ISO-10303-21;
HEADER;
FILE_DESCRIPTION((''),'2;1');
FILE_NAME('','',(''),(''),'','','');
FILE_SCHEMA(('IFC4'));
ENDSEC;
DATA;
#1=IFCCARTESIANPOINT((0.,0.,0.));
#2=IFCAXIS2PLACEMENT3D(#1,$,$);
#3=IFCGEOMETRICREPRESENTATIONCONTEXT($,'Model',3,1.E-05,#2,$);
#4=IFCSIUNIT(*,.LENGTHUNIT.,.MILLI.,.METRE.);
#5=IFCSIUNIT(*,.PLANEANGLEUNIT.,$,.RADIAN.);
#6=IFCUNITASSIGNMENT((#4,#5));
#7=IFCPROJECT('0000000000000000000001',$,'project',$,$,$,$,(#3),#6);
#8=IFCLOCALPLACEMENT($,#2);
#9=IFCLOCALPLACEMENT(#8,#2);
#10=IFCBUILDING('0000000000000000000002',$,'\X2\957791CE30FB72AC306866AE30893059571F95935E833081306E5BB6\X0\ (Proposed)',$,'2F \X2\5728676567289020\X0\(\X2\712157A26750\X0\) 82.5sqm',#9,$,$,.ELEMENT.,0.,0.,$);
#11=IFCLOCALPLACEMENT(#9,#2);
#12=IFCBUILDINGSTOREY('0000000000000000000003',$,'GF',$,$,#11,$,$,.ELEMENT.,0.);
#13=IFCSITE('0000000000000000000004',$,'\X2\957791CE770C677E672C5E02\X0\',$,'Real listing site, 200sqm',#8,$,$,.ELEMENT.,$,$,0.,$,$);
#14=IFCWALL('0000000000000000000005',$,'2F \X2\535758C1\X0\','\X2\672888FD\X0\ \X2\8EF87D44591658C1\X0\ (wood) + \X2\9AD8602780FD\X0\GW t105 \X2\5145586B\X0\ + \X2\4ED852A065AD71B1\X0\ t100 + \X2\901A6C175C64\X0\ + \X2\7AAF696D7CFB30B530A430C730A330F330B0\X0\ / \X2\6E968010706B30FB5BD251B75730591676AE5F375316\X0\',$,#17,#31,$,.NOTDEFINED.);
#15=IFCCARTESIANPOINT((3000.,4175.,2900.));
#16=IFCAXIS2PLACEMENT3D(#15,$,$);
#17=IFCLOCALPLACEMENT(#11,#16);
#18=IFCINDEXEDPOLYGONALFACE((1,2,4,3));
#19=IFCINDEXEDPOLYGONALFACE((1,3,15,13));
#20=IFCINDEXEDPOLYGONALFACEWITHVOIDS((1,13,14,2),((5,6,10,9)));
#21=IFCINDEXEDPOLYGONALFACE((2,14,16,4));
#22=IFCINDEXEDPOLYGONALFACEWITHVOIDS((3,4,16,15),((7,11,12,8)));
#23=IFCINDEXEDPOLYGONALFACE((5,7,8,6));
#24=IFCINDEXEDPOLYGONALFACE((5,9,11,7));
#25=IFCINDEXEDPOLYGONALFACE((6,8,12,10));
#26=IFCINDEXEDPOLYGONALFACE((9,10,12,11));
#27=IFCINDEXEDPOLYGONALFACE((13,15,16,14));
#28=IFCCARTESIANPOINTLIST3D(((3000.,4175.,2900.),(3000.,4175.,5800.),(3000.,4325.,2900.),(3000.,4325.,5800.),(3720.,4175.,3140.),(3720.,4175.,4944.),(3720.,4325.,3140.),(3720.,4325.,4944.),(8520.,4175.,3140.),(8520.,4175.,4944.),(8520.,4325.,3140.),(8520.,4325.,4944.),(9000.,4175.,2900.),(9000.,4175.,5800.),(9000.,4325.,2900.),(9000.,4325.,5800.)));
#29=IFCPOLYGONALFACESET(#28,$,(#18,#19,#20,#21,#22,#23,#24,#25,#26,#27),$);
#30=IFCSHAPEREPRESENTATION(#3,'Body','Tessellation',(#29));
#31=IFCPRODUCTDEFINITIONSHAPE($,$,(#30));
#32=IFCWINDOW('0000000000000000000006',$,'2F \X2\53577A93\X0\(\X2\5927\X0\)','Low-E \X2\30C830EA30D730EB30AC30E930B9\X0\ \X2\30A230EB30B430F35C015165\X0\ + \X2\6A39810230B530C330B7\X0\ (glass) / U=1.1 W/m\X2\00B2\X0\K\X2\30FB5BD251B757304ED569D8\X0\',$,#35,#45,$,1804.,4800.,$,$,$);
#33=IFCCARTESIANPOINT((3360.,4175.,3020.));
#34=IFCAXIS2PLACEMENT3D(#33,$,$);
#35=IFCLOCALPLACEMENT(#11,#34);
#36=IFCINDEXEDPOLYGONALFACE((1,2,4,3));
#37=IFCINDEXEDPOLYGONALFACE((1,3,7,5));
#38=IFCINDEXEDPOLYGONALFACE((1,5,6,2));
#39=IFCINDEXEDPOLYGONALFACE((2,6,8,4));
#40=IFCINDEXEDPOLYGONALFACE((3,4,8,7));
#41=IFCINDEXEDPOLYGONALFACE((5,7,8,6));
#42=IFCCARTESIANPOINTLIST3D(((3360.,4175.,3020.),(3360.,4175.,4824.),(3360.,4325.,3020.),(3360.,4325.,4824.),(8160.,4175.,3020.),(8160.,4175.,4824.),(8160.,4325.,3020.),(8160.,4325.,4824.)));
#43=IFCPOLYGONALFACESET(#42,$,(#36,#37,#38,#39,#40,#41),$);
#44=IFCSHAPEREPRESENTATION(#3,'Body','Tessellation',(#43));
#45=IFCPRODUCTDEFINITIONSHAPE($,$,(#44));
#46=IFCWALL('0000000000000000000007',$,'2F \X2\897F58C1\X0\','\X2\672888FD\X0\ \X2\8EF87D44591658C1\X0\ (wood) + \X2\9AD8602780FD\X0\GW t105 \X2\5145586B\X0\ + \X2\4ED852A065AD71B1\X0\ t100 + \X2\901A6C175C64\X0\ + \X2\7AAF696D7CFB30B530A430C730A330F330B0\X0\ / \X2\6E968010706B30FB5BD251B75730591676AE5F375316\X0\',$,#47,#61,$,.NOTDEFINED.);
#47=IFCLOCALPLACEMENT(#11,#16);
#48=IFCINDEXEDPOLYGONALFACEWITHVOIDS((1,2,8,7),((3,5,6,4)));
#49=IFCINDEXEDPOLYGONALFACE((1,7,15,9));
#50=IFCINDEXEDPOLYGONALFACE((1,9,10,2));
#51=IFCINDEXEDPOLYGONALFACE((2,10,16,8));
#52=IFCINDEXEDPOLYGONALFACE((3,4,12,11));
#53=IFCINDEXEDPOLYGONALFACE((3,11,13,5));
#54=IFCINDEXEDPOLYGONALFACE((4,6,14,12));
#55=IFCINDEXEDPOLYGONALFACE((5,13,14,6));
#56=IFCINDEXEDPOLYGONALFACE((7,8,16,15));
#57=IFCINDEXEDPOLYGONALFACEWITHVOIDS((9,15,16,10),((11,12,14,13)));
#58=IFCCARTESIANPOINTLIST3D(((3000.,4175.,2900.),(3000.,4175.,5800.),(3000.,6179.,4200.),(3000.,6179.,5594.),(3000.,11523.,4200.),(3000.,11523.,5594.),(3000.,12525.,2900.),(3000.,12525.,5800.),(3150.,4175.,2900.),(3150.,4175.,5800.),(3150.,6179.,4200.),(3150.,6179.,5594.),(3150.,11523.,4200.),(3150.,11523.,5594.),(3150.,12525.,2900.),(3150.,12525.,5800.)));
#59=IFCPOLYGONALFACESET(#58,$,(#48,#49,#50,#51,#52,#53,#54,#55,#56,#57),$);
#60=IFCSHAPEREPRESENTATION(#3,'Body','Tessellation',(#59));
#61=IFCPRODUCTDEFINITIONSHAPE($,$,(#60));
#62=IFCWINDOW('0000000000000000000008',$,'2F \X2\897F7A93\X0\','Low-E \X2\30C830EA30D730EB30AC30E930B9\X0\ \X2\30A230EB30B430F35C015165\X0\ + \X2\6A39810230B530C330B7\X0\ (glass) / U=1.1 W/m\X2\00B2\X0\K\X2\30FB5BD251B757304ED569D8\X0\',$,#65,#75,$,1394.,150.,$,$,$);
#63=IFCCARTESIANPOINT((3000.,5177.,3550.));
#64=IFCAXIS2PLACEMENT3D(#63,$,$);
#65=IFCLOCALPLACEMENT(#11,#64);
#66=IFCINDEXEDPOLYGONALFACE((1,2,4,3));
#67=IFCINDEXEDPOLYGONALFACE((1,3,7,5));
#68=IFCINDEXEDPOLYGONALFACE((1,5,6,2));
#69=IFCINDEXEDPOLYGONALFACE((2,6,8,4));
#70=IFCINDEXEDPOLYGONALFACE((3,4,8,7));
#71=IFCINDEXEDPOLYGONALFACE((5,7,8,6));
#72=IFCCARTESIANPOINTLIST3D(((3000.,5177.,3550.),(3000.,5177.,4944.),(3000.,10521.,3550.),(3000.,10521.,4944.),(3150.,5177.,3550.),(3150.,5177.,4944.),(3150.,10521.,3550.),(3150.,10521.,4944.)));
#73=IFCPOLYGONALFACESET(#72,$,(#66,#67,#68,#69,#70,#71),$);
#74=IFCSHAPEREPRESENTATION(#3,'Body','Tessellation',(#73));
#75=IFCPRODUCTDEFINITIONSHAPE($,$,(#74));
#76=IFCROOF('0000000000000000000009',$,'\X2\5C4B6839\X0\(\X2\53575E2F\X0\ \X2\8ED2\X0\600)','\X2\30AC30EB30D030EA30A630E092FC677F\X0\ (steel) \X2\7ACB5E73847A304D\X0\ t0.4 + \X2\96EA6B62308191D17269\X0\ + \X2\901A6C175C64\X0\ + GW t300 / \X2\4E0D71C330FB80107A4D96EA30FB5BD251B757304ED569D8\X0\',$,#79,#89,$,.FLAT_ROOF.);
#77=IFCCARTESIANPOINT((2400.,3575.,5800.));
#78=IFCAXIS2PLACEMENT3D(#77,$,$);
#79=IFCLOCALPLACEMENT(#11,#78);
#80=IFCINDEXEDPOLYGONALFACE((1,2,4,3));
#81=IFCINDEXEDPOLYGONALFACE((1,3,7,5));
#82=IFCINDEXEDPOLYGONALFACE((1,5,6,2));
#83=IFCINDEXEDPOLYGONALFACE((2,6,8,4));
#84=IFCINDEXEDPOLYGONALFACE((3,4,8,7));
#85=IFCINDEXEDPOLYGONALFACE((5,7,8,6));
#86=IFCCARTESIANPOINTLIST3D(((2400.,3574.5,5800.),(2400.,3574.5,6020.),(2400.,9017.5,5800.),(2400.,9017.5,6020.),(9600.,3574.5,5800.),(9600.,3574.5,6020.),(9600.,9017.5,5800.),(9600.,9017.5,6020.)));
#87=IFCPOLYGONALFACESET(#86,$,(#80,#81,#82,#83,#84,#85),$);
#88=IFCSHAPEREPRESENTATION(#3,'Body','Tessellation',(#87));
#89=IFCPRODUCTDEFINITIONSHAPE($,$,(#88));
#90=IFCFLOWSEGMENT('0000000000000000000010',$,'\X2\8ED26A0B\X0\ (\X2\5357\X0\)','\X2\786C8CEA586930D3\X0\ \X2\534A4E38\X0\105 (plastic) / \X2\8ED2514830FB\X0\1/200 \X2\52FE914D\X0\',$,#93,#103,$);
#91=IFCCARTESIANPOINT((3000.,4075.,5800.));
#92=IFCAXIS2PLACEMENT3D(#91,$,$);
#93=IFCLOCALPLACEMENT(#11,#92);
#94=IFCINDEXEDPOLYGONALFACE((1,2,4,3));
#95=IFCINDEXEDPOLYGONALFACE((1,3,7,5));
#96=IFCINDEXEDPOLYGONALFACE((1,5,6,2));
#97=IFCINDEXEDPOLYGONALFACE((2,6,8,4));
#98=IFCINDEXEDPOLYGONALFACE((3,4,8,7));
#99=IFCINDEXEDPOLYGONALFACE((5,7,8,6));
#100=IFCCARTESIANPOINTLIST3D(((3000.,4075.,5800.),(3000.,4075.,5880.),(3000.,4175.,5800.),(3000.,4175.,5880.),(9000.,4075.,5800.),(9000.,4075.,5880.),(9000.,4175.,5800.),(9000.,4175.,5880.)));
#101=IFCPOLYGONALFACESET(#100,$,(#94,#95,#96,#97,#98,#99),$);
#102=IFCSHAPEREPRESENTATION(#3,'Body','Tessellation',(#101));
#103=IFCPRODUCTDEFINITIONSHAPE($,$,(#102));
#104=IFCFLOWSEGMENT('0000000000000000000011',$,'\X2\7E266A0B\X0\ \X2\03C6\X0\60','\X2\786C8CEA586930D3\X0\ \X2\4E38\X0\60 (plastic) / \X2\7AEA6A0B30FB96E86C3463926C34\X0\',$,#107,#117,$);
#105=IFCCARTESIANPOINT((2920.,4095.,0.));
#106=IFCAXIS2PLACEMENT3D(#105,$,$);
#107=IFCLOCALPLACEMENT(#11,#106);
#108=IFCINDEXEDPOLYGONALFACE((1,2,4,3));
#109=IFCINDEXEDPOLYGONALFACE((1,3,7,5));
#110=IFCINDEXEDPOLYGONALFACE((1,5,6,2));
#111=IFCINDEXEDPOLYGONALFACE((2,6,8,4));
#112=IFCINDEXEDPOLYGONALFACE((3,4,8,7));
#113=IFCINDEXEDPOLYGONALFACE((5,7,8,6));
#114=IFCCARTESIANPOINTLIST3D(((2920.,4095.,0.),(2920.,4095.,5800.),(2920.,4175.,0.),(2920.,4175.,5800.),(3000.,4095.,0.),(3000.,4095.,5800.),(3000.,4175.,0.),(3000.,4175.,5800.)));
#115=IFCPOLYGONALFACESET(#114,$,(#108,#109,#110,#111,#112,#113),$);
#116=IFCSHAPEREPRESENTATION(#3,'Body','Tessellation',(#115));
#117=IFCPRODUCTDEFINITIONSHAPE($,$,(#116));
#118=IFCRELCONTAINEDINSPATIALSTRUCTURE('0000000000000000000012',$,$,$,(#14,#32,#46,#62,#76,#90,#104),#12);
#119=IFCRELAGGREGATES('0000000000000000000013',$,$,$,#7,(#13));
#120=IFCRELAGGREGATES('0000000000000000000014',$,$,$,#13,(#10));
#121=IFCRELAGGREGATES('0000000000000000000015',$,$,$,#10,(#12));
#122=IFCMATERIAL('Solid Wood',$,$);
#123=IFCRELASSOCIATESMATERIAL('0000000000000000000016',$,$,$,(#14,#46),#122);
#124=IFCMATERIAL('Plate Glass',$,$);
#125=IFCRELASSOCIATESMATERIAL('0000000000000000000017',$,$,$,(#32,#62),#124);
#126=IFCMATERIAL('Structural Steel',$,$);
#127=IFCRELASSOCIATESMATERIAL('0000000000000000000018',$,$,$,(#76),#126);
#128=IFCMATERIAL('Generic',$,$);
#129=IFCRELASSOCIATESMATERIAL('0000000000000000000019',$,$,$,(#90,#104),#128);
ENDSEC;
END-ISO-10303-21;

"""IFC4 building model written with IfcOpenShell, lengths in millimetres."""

from ifc_helpers import new_model, si_unit, frame, frame_2d, origin, place, context, project, spatial, rectangle, extrude, material, element, fill, save


model = new_model("IFC4")

# Units and contexts
model_context = context("Model", 3, precision=1e-05, world=origin())
ifc_project = project(units=[si_unit("LENGTHUNIT", "METRE", prefix="MILLI"), si_unit("PLANEANGLEUNIT", "RADIAN")], contexts=[model_context])

# Site, building, storey
site_placement = place(None, origin())
site = spatial("IfcSite", under=ifc_project, at=site_placement, Name="長野県松本市", ObjectType="Real listing site, 200sqm", CompositionType="ELEMENT", RefElevation=0.0)
building_placement = place(site_placement, origin())
building = spatial("IfcBuilding", under=site, at=building_placement, Name="長野・犬と暮らす土間広めの家 (Proposed)", ObjectType="2F 在来木造(無垢材) 82.5sqm", CompositionType="ELEMENT", ElevationOfRefHeight=0.0, ElevationOfTerrain=0.0)
storey_placement = place(building_placement, origin())
storey = spatial("IfcBuildingStorey", under=building, at=storey_placement, Name="GF", CompositionType="ELEMENT", Elevation=0.0)

# Shared definitions
ifc_material_1 = material(Name="Solid Wood")

# Shared definitions
ifc_material_2 = material(Name="Plate Glass")

# Walls, openings, windows
wall_1_placement = place(storey_placement, frame((3000.0, 4175.0, 2900.0)))
wall_1 = element("IfcWall", 1, at=wall_1_placement, inside=storey, material=ifc_material_1, Name="2F 南壁", Description="木製 軸組外壁 (wood) + 高性能GW t105 充填 + 付加断熱 t100 + 通気層 + 窯業系サイディング / 準耐火・寒冷地外皮強化", PredefinedType="NOTDEFINED", context=model_context, shape_type="SweptSolid", body=[
    extrude(rectangle(XDim=6000.0, YDim=150.0, at=frame_2d((3000.0, 75.0))), frame((3000.0, 4175.0, 2900.0)), (0.0, 0.0, 1.0), 2900.0),
])
opening_1_placement = place(storey_placement, frame((3360.0, 4175.0, 3020.0)))
opening_1 = element("IfcOpeningElement", 2, at=opening_1_placement, cuts=wall_1, PredefinedType="NOTDEFINED", context=model_context, shape_type="SweptSolid", body=[
    extrude(rectangle(XDim=4800.0, YDim=150.0, at=frame_2d((2400.0, 75.0))), frame((3360.0, 4175.0, 3020.0)), (0.0, 0.0, 1.0), 1804.0),
])
window_1_placement = place(storey_placement, frame((3360.0, 4175.0, 3020.0)))
window_1 = element("IfcWindow", 3, at=window_1_placement, inside=storey, material=ifc_material_2, Name="2F 南窓(大)", Description="Low-E トリプルガラス アルゴン封入 + 樹脂サッシ (glass) / U=1.1 W/m²K・寒冷地仕様", OverallHeight=1804.0, OverallWidth=4800.0, context=model_context, shape_type="SweptSolid", body=[
    extrude(rectangle(XDim=4800.0, YDim=150.0, at=frame_2d((2400.0, 75.0))), frame((3360.0, 4175.0, 3020.0)), (0.0, 0.0, 1.0), 1804.0),
])
fill(opening_1, window_1)
wall_2_placement = place(storey_placement, frame((3000.0, 4175.0, 2900.0)))
wall_2 = element("IfcWall", 4, at=wall_2_placement, inside=storey, material=ifc_material_1, Name="2F 西壁", Description="木製 軸組外壁 (wood) + 高性能GW t105 充填 + 付加断熱 t100 + 通気層 + 窯業系サイディング / 準耐火・寒冷地外皮強化", PredefinedType="NOTDEFINED", context=model_context, shape_type="SweptSolid", body=[
    extrude(rectangle(XDim=150.0, YDim=8350.0, at=frame_2d((75.0, 4175.0))), frame((3000.0, 4175.0, 2900.0)), (0.0, 0.0, 1.0), 2900.0),
])
opening_2_placement = place(storey_placement, frame((3000.0, 5177.0, 3550.0)))
opening_2 = element("IfcOpeningElement", 5, at=opening_2_placement, cuts=wall_2, PredefinedType="NOTDEFINED", context=model_context, shape_type="SweptSolid", body=[
    extrude(rectangle(XDim=150.0, YDim=5344.0, at=frame_2d((75.0, 2672.0))), frame((3000.0, 5177.0, 3550.0)), (0.0, 0.0, 1.0), 1394.0),
])
window_2_placement = place(storey_placement, frame((3000.0, 5177.0, 3550.0)))
window_2 = element("IfcWindow", 6, at=window_2_placement, inside=storey, material=ifc_material_2, Name="2F 西窓", Description="Low-E トリプルガラス アルゴン封入 + 樹脂サッシ (glass) / U=1.1 W/m²K・寒冷地仕様", OverallHeight=1394.0, OverallWidth=150.0, context=model_context, shape_type="SweptSolid", body=[
    extrude(rectangle(XDim=150.0, YDim=5344.0, at=frame_2d((75.0, 2672.0))), frame((3000.0, 5177.0, 3550.0)), (0.0, 0.0, 1.0), 1394.0),
])
fill(opening_2, window_2)

# Roof
ifc_material_3 = material(Name="Structural Steel")
for number, where, name in (
    (7, (2400.0, 3575.0, 5800.0), "屋根(南帯 軒600)"),
):
    element("IfcRoof", number, at=place(storey_placement, frame(where)), inside=storey, material=ifc_material_3, Name=name, Description="ガルバリウム鋼板 (steel) 立平葺き t0.4 + 雪止め金物 + 通気層 + GW t300 / 不燃・耐積雪・寒冷地仕様", PredefinedType="FLAT_ROOF", context=model_context, shape_type="SweptSolid", body=[
        extrude(rectangle(XDim=7200.0, YDim=5443.0, at=frame_2d((3600.0, 2721.0))), frame((2400.0, 3575.0, 5800.0)), (0.0, 0.0, 1.0), 220.0),
    ])

# Flow segments
ifc_material_4 = material(Name="Generic")
flow_segment_1_placement = place(storey_placement, frame((3000.0, 4075.0, 5800.0)))
element("IfcFlowSegment", 8, at=flow_segment_1_placement, inside=storey, material=ifc_material_4, Name="軒樋 (南)", Description="硬質塩ビ 半丸105 (plastic) / 軒先・1/200 勾配", context=model_context, shape_type="SweptSolid", body=[
    extrude(rectangle(XDim=6000.0, YDim=100.0, at=frame_2d((3000.0, 50.0))), frame((3000.0, 4075.0, 5800.0)), (0.0, 0.0, 1.0), 80.0),
])
flow_segment_2_placement = place(storey_placement, frame((2920.0, 4095.0, 0.0)))
element("IfcFlowSegment", 9, at=flow_segment_2_placement, inside=storey, material=ifc_material_4, Name="縦樋 φ60", Description="硬質塩ビ 丸60 (plastic) / 竪樋・雨水排水", context=model_context, shape_type="SweptSolid", body=[
    extrude(rectangle(XDim=80.0, YDim=80.0, at=frame_2d((40.0, 40.0))), frame((2920.0, 4095.0, 0.0)), (0.0, 0.0, 1.0), 5800.0),
])

save(model, "model.ifc")
